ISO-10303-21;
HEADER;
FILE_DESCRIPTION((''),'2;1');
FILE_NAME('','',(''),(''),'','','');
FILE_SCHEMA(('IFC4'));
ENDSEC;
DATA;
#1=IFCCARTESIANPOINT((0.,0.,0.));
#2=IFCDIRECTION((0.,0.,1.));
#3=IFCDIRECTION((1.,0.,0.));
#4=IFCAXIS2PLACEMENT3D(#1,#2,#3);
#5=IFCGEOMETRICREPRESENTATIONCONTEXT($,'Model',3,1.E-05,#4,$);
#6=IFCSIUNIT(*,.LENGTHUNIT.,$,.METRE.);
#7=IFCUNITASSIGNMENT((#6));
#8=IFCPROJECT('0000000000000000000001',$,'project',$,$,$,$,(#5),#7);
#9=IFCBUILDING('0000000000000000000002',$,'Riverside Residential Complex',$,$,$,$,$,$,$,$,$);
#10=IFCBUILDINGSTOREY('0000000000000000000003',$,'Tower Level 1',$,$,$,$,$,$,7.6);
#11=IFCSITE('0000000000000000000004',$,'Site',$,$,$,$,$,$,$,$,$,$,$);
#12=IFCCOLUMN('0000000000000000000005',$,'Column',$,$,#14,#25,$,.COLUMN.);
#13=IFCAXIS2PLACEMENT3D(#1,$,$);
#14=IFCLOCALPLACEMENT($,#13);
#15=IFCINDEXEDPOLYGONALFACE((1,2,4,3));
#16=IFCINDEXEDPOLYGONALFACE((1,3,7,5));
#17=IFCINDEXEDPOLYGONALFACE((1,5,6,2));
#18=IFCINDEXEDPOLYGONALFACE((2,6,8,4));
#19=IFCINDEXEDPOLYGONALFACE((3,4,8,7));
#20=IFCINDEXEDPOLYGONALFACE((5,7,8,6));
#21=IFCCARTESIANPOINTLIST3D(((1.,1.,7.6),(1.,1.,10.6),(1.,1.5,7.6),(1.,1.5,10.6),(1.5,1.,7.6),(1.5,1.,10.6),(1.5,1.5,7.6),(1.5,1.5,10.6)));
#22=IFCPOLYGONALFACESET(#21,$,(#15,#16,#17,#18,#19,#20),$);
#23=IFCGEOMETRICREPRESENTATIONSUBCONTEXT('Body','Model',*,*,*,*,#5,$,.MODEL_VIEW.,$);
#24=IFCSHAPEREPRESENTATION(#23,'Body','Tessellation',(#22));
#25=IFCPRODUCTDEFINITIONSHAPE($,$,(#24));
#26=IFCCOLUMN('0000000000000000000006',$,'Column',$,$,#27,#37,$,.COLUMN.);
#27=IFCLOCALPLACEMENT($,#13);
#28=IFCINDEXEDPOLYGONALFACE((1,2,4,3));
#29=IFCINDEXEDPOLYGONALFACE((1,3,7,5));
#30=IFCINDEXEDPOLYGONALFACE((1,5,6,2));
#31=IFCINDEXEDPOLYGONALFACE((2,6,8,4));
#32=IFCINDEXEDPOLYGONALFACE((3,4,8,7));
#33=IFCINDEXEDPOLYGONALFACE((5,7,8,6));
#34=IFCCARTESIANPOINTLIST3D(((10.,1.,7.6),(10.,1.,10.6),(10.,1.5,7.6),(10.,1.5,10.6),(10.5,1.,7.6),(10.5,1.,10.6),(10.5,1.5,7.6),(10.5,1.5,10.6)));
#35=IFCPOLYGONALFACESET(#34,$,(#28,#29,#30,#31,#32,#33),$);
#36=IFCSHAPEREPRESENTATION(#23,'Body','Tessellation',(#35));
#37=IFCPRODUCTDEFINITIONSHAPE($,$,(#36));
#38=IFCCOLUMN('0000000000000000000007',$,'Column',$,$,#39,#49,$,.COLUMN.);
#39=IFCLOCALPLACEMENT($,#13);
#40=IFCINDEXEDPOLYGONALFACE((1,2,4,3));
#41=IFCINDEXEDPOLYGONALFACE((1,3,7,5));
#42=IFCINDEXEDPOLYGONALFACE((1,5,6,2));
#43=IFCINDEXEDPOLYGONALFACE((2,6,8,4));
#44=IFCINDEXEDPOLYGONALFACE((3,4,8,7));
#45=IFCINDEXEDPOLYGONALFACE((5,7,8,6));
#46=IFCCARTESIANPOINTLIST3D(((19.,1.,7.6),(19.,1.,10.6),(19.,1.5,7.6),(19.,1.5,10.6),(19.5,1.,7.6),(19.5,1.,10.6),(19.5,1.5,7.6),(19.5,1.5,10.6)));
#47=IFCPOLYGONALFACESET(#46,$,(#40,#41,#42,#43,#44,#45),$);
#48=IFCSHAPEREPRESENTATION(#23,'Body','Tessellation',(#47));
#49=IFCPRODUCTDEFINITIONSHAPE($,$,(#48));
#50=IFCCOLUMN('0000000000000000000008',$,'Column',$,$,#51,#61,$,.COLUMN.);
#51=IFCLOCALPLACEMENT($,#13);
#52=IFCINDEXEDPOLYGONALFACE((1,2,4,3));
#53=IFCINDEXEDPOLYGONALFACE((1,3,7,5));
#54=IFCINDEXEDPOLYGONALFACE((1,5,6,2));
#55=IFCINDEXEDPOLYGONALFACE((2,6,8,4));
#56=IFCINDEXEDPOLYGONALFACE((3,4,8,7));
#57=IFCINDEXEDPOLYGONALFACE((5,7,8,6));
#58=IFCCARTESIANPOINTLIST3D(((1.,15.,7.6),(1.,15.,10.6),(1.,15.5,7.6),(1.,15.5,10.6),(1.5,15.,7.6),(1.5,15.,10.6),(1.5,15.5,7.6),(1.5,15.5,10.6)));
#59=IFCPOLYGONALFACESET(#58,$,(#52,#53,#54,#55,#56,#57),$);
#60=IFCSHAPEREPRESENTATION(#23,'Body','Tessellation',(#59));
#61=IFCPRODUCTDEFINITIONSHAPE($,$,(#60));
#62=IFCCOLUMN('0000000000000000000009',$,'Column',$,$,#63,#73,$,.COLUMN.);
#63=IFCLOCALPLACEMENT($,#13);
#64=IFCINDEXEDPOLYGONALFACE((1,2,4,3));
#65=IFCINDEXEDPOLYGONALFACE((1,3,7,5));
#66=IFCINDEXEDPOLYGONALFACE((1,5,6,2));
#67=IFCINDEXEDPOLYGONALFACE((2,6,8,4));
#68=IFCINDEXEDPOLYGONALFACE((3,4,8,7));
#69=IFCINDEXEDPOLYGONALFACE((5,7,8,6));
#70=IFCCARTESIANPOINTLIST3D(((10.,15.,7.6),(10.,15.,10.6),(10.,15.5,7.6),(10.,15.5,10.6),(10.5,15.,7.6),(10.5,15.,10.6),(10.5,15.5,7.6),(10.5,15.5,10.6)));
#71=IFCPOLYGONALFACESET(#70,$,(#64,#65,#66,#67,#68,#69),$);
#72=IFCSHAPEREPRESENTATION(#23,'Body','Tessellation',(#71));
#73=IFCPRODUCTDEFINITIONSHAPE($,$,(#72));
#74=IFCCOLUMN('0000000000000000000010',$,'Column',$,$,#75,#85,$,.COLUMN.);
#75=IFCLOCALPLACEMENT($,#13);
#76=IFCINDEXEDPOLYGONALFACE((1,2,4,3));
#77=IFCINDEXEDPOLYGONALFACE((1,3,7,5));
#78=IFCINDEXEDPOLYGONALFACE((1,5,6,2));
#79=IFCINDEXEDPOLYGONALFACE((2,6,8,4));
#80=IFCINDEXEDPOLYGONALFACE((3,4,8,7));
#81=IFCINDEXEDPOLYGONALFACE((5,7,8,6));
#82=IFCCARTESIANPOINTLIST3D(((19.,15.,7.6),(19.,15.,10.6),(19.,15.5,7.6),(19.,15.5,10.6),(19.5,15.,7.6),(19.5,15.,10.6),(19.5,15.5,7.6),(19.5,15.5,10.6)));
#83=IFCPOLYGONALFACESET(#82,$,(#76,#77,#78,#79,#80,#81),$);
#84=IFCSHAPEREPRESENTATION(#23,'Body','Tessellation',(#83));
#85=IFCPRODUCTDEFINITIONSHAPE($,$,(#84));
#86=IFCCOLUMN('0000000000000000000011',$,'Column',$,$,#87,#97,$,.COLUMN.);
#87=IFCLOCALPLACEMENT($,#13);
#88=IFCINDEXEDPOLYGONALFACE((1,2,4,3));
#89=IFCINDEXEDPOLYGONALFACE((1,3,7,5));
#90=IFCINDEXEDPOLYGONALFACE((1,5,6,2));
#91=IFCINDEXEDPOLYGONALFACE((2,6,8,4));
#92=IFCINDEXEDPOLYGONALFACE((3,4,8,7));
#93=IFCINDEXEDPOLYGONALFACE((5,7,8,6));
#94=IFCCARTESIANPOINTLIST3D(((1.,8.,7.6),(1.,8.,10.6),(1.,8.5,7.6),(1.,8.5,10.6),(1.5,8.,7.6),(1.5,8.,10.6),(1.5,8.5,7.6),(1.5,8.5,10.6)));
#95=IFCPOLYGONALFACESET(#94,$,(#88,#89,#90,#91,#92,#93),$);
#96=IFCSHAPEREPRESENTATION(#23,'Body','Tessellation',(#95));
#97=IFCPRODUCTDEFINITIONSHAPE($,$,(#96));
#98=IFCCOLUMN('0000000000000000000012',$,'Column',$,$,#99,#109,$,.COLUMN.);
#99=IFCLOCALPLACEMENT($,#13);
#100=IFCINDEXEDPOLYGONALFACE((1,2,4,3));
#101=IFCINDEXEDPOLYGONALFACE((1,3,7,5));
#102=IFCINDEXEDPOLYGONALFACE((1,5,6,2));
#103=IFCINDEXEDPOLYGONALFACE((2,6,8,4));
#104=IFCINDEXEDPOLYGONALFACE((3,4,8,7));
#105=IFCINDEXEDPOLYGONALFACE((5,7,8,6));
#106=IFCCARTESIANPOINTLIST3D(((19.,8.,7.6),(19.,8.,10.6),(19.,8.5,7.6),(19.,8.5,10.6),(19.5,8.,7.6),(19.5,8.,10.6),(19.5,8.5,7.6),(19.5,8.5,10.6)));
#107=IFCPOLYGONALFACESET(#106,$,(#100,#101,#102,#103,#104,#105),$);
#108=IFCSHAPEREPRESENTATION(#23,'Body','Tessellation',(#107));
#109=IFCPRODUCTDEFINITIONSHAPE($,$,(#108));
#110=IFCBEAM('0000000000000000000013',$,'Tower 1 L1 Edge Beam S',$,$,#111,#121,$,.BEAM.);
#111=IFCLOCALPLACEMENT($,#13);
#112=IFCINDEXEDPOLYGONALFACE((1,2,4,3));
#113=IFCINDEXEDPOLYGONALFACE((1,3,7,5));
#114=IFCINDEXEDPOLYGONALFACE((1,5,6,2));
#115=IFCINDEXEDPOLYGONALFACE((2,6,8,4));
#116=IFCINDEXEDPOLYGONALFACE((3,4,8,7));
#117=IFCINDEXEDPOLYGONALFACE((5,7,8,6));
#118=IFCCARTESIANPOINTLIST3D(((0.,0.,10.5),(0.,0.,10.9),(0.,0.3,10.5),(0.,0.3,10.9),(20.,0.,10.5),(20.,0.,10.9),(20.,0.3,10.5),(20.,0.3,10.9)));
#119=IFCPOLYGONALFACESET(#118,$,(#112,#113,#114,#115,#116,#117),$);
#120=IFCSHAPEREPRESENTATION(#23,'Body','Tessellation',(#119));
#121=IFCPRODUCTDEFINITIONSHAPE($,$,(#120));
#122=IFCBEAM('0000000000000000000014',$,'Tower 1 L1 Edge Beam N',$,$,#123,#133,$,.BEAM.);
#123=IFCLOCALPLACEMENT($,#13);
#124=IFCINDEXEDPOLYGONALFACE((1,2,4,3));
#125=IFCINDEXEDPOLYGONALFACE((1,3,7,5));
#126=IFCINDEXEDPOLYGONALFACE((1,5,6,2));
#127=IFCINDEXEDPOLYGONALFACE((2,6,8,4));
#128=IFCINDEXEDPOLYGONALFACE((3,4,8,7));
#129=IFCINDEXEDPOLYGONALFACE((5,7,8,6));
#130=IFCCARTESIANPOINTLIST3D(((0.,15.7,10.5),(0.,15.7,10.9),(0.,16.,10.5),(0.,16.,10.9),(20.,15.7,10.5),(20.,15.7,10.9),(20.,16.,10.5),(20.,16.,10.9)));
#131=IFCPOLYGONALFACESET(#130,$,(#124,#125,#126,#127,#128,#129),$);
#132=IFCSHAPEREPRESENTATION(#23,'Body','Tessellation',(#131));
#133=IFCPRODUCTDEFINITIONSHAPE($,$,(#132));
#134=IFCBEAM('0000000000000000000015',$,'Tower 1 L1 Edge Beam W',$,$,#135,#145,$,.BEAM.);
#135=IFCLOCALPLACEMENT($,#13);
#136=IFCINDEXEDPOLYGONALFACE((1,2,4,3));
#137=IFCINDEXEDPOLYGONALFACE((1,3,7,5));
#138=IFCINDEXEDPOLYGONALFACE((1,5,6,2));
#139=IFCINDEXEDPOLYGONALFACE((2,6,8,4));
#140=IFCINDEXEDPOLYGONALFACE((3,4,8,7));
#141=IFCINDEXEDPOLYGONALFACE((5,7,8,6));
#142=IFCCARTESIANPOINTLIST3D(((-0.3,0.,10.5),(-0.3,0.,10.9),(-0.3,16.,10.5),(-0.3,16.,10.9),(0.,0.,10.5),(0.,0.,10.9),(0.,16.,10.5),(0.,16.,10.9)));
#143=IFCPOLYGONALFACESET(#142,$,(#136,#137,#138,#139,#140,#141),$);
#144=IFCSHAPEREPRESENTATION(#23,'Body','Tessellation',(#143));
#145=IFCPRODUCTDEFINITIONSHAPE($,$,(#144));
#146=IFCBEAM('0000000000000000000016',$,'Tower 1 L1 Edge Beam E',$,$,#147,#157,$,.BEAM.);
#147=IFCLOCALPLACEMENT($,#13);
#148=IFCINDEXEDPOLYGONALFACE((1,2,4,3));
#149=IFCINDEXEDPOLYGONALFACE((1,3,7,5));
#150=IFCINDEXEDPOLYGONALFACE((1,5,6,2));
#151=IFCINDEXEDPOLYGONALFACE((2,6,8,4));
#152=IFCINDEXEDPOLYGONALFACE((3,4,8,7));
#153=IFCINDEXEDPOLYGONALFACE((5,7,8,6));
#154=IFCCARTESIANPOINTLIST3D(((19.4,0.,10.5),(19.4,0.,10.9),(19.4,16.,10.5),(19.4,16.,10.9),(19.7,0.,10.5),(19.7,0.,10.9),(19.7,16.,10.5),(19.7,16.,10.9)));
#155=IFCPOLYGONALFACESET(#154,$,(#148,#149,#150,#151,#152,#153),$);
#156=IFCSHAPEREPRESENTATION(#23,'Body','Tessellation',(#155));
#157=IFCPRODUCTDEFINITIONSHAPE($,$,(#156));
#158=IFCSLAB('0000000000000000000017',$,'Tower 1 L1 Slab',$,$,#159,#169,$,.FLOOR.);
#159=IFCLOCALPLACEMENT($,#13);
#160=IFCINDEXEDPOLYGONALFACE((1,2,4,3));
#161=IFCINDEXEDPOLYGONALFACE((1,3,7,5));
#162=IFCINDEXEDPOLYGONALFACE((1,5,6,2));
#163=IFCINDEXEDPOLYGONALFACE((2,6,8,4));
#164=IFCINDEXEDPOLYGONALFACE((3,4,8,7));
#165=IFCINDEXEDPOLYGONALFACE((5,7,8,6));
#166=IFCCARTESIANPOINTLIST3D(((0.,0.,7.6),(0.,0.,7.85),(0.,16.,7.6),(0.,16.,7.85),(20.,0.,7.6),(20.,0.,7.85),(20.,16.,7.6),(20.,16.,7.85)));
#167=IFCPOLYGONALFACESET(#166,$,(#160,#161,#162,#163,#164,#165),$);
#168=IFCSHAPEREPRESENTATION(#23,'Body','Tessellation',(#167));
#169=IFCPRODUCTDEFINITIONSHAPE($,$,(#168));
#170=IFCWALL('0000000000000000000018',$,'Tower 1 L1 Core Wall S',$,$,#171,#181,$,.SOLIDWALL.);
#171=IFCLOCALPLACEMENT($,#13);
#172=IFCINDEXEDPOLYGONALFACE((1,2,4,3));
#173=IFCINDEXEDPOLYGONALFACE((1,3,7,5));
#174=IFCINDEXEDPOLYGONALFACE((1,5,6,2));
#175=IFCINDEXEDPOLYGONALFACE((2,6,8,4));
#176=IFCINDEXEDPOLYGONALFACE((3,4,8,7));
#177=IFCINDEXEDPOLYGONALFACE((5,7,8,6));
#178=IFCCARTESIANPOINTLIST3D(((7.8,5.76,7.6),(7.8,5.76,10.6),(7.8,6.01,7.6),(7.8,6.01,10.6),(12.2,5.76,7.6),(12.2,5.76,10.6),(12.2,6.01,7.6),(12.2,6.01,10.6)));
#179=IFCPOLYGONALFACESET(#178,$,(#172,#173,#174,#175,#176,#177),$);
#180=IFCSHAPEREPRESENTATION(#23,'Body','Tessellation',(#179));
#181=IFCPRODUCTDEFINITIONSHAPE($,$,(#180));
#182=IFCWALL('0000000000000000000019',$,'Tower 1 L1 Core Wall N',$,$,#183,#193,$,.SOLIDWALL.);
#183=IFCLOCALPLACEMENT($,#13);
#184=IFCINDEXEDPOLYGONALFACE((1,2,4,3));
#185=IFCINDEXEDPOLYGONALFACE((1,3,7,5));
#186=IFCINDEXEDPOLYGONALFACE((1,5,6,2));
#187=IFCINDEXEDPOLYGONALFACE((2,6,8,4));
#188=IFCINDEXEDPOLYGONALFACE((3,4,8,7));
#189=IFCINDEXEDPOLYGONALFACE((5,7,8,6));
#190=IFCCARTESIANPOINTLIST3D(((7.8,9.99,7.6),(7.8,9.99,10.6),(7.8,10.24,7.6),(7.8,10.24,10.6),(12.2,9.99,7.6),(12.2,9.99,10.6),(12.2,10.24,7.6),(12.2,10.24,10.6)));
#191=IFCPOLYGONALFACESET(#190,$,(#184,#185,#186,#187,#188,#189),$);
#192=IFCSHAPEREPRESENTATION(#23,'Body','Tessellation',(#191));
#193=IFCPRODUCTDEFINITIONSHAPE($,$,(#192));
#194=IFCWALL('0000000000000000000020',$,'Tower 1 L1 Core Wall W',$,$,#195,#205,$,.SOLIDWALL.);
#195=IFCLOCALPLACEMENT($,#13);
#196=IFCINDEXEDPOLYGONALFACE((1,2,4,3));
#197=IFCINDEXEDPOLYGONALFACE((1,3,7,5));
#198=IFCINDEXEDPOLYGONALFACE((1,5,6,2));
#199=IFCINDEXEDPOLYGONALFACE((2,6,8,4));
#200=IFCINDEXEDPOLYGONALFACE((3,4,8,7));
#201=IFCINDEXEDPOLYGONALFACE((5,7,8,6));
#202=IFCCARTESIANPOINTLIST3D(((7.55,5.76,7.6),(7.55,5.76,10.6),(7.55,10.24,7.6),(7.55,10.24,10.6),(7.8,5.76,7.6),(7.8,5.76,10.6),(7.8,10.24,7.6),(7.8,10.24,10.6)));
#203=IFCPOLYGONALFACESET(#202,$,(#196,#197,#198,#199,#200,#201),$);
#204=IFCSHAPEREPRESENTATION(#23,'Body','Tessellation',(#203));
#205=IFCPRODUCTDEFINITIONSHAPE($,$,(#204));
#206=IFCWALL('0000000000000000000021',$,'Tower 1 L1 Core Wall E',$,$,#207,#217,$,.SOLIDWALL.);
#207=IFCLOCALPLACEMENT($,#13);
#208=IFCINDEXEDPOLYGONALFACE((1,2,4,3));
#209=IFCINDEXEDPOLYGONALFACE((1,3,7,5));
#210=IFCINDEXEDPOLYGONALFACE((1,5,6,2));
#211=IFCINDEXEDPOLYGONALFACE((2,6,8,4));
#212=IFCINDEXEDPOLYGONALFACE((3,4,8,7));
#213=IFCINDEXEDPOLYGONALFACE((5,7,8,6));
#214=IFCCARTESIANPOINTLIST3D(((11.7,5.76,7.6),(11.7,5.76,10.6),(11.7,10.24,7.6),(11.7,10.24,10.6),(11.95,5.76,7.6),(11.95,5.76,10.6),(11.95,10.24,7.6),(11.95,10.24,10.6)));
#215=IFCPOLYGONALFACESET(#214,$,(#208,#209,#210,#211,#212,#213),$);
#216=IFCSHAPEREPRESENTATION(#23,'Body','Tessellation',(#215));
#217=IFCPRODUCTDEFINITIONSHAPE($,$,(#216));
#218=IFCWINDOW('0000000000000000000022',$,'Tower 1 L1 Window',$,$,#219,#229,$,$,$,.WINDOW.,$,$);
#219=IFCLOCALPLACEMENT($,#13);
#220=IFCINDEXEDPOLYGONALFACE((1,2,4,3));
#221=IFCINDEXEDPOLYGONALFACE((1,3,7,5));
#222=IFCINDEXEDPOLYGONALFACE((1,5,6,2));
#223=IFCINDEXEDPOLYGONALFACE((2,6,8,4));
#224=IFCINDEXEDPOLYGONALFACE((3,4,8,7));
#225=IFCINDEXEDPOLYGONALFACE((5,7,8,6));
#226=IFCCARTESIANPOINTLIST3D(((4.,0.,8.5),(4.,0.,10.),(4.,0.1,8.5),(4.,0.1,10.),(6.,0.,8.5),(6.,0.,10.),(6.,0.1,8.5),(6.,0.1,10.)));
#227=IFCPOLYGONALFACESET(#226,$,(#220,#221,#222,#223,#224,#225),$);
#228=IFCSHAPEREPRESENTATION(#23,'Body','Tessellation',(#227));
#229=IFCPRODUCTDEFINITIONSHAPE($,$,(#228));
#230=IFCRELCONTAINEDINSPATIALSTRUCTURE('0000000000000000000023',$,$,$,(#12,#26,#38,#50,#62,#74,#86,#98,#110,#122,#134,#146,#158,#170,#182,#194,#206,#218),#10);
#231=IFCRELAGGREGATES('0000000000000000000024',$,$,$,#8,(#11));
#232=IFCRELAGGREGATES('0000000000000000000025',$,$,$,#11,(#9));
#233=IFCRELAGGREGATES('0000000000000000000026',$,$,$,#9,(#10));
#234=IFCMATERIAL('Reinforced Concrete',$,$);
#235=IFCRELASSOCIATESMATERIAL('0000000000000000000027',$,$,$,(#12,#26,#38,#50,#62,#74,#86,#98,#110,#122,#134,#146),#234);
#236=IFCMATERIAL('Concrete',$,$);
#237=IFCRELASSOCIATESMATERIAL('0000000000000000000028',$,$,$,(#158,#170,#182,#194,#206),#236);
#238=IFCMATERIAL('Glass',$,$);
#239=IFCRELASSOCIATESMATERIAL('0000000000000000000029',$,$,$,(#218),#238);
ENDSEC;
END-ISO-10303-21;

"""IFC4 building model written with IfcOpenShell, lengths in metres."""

from ifc_helpers import new_model, si_unit, frame, origin_with_axes, place, context, subcontext, project, spatial, line, indexed_curve, outline, extrude, material, element, save


model = new_model("IFC4")

# Units and contexts
model_context = context("Model", 3, precision=1e-05, world=origin_with_axes())
body_context = subcontext(model_context, "Body", "Model", "MODEL_VIEW")
ifc_project = project(units=[si_unit("LENGTHUNIT", "METRE")], contexts=[model_context])

# Site, building, storey
site = spatial("IfcSite", under=ifc_project, Name="Site")
building = spatial("IfcBuilding", under=site, Name="Riverside Residential Complex")
storey = spatial("IfcBuildingStorey", under=building, Name="Tower Level 1", Elevation=7.6)

# Columns
ifc_material_1 = material(Name="Reinforced Concrete")
for number, where, z_axis, x_axis, name in (
    (1, (1.0, 1.0, 7.6), (0.0, 0.0, 1.0), (1.0, 0.0, 0.0), "Column"),
    (2, (10.0, 1.0, 7.6), (0.0, 0.0, 1.0), (1.0, 0.0, 0.0), "Column"),
    (3, (19.0, 1.0, 7.6), (0.0, 0.0, 1.0), (1.0, 0.0, 0.0), "Column"),
    (4, (1.0, 15.0, 7.6), (0.0, 0.0, 1.0), (1.0, 0.0, 0.0), "Column"),
    (5, (10.0, 15.0, 7.6), (0.0, 0.0, 1.0), (1.0, 0.0, 0.0), "Column"),
    (6, (19.0, 15.0, 7.6), (0.0, 0.0, 1.0), (1.0, 0.0, 0.0), "Column"),
    (7, (1.0, 8.0, 7.6), (0.0, 0.0, 1.0), (1.0, 0.0, 0.0), "Column"),
    (8, (19.0, 8.0, 7.6), (0.0, 0.0, 1.0), (1.0, 0.0, 0.0), "Column"),
):
    element("IfcColumn", number, at=place(None, frame(where, z_axis=z_axis, x_axis=x_axis)), inside=storey, material=ifc_material_1, Name=name, PredefinedType="COLUMN", context=body_context, shape_type="SweptSolid", body=[
        extrude(outline(indexed_curve([(0.0, 0.0), (0.5, 0.0), (0.5, 0.5), (0.0, 0.5)], segments=[line(1, 2, 3, 4, 1)])), origin_with_axes(), (0.0, 0.0, 1.0), 3.0),
    ])

# Beams
for number, where, z_axis, x_axis, name in (
    (9, (0.0, 0.0, 10.5), (0.0, 0.0, 1.0), (1.0, 0.0, 0.0), "Tower 1 L1 Edge Beam S"),
    (10, (0.0, 15.7, 10.5), (0.0, 0.0, 1.0), (1.0, 0.0, 0.0), "Tower 1 L1 Edge Beam N"),
):
    element("IfcBeam", number, at=place(None, frame(where, z_axis=z_axis, x_axis=x_axis)), inside=storey, material=ifc_material_1, Name=name, PredefinedType="BEAM", context=body_context, shape_type="SweptSolid", body=[
        extrude(outline(indexed_curve([(0.0, 0.0), (20.0, 0.0), (20.0, 0.3), (0.0, 0.3)], segments=[line(1, 2, 3, 4, 1)])), origin_with_axes(), (0.0, 0.0, 1.0), 0.4),
    ])
for number, where, z_axis, x_axis, name in (
    (11, (0.0, 0.0, 10.5), (0.0, 0.0, 1.0), (0.0, 1.0, 0.0), "Tower 1 L1 Edge Beam W"),
    (12, (19.7, 0.0, 10.5), (0.0, 0.0, 1.0), (0.0, 1.0, 0.0), "Tower 1 L1 Edge Beam E"),
):
    element("IfcBeam", number, at=place(None, frame(where, z_axis=z_axis, x_axis=x_axis)), inside=storey, material=ifc_material_1, Name=name, PredefinedType="BEAM", context=body_context, shape_type="SweptSolid", body=[
        extrude(outline(indexed_curve([(0.0, 0.0), (16.0, 0.0), (16.0, 0.3), (0.0, 0.3)], segments=[line(1, 2, 3, 4, 1)])), origin_with_axes(), (0.0, 0.0, 1.0), 0.4),
    ])

# Slab
ifc_material_2 = material(Name="Concrete")
slab_placement = place(None, frame((0.0, 0.0, 7.6), z_axis=(0.0, 0.0, 1.0), x_axis=(1.0, 0.0, 0.0)))
element("IfcSlab", 13, at=slab_placement, inside=storey, material=ifc_material_2, Name="Tower 1 L1 Slab", PredefinedType="FLOOR", context=body_context, shape_type="SweptSolid", body=[
    extrude(outline(indexed_curve([(0.0, 0.0), (20.0, 0.0), (20.0, 16.0), (0.0, 16.0)], segments=[line(1, 2, 3, 4, 1)])), origin_with_axes(), (0.0, 0.0, 1.0), 0.25),
])

# Walls
for number, where, z_axis, x_axis, name in (
    (14, (7.8, 5.76, 7.6), (0.0, 0.0, 1.0), (1.0, 0.0, 0.0), "Tower 1 L1 Core Wall S"),
    (15, (7.8, 9.99, 7.6), (0.0, 0.0, 1.0), (1.0, 0.0, 0.0), "Tower 1 L1 Core Wall N"),
):
    element("IfcWall", number, at=place(None, frame(where, z_axis=z_axis, x_axis=x_axis)), inside=storey, material=ifc_material_2, Name=name, PredefinedType="SOLIDWALL", context=body_context, shape_type="SweptSolid", body=[
        extrude(outline(indexed_curve([(0.0, 0.0), (4.4, 0.0), (4.4, 0.25), (0.0, 0.25)], segments=[line(1, 2, 3, 4, 1)])), origin_with_axes(), (0.0, 0.0, 1.0), 3.0),
    ])
for number, where, z_axis, x_axis, name in (
    (16, (7.8, 5.76, 7.6), (0.0, 0.0, 1.0), (0.0, 1.0, 0.0), "Tower 1 L1 Core Wall W"),
    (17, (11.95, 5.76, 7.6), (0.0, 0.0, 1.0), (0.0, 1.0, 0.0), "Tower 1 L1 Core Wall E"),
):
    element("IfcWall", number, at=place(None, frame(where, z_axis=z_axis, x_axis=x_axis)), inside=storey, material=ifc_material_2, Name=name, PredefinedType="SOLIDWALL", context=body_context, shape_type="SweptSolid", body=[
        extrude(outline(indexed_curve([(0.0, 0.0), (4.48, 0.0), (4.48, 0.25), (0.0, 0.25)], segments=[line(1, 2, 3, 4, 1)])), origin_with_axes(), (0.0, 0.0, 1.0), 3.0),
    ])

# Window
ifc_material_3 = material(Name="Glass")
for number, where, z_axis, x_axis, name in (
    (18, (4.0, 0.0, 8.5), (0.0, 0.0, 1.0), (1.0, 0.0, 0.0), "Tower 1 L1 Window"),
):
    element("IfcWindow", number, at=place(None, frame(where, z_axis=z_axis, x_axis=x_axis)), inside=storey, material=ifc_material_3, Name=name, PredefinedType="WINDOW", context=body_context, shape_type="SweptSolid", body=[
        extrude(outline(indexed_curve([(0.0, 0.0), (2.0, 0.0), (2.0, 0.1), (0.0, 0.1)], segments=[line(1, 2, 3, 4, 1)])), origin_with_axes(), (0.0, 0.0, 1.0), 1.5),
    ])

save(model, "model.ifc")
